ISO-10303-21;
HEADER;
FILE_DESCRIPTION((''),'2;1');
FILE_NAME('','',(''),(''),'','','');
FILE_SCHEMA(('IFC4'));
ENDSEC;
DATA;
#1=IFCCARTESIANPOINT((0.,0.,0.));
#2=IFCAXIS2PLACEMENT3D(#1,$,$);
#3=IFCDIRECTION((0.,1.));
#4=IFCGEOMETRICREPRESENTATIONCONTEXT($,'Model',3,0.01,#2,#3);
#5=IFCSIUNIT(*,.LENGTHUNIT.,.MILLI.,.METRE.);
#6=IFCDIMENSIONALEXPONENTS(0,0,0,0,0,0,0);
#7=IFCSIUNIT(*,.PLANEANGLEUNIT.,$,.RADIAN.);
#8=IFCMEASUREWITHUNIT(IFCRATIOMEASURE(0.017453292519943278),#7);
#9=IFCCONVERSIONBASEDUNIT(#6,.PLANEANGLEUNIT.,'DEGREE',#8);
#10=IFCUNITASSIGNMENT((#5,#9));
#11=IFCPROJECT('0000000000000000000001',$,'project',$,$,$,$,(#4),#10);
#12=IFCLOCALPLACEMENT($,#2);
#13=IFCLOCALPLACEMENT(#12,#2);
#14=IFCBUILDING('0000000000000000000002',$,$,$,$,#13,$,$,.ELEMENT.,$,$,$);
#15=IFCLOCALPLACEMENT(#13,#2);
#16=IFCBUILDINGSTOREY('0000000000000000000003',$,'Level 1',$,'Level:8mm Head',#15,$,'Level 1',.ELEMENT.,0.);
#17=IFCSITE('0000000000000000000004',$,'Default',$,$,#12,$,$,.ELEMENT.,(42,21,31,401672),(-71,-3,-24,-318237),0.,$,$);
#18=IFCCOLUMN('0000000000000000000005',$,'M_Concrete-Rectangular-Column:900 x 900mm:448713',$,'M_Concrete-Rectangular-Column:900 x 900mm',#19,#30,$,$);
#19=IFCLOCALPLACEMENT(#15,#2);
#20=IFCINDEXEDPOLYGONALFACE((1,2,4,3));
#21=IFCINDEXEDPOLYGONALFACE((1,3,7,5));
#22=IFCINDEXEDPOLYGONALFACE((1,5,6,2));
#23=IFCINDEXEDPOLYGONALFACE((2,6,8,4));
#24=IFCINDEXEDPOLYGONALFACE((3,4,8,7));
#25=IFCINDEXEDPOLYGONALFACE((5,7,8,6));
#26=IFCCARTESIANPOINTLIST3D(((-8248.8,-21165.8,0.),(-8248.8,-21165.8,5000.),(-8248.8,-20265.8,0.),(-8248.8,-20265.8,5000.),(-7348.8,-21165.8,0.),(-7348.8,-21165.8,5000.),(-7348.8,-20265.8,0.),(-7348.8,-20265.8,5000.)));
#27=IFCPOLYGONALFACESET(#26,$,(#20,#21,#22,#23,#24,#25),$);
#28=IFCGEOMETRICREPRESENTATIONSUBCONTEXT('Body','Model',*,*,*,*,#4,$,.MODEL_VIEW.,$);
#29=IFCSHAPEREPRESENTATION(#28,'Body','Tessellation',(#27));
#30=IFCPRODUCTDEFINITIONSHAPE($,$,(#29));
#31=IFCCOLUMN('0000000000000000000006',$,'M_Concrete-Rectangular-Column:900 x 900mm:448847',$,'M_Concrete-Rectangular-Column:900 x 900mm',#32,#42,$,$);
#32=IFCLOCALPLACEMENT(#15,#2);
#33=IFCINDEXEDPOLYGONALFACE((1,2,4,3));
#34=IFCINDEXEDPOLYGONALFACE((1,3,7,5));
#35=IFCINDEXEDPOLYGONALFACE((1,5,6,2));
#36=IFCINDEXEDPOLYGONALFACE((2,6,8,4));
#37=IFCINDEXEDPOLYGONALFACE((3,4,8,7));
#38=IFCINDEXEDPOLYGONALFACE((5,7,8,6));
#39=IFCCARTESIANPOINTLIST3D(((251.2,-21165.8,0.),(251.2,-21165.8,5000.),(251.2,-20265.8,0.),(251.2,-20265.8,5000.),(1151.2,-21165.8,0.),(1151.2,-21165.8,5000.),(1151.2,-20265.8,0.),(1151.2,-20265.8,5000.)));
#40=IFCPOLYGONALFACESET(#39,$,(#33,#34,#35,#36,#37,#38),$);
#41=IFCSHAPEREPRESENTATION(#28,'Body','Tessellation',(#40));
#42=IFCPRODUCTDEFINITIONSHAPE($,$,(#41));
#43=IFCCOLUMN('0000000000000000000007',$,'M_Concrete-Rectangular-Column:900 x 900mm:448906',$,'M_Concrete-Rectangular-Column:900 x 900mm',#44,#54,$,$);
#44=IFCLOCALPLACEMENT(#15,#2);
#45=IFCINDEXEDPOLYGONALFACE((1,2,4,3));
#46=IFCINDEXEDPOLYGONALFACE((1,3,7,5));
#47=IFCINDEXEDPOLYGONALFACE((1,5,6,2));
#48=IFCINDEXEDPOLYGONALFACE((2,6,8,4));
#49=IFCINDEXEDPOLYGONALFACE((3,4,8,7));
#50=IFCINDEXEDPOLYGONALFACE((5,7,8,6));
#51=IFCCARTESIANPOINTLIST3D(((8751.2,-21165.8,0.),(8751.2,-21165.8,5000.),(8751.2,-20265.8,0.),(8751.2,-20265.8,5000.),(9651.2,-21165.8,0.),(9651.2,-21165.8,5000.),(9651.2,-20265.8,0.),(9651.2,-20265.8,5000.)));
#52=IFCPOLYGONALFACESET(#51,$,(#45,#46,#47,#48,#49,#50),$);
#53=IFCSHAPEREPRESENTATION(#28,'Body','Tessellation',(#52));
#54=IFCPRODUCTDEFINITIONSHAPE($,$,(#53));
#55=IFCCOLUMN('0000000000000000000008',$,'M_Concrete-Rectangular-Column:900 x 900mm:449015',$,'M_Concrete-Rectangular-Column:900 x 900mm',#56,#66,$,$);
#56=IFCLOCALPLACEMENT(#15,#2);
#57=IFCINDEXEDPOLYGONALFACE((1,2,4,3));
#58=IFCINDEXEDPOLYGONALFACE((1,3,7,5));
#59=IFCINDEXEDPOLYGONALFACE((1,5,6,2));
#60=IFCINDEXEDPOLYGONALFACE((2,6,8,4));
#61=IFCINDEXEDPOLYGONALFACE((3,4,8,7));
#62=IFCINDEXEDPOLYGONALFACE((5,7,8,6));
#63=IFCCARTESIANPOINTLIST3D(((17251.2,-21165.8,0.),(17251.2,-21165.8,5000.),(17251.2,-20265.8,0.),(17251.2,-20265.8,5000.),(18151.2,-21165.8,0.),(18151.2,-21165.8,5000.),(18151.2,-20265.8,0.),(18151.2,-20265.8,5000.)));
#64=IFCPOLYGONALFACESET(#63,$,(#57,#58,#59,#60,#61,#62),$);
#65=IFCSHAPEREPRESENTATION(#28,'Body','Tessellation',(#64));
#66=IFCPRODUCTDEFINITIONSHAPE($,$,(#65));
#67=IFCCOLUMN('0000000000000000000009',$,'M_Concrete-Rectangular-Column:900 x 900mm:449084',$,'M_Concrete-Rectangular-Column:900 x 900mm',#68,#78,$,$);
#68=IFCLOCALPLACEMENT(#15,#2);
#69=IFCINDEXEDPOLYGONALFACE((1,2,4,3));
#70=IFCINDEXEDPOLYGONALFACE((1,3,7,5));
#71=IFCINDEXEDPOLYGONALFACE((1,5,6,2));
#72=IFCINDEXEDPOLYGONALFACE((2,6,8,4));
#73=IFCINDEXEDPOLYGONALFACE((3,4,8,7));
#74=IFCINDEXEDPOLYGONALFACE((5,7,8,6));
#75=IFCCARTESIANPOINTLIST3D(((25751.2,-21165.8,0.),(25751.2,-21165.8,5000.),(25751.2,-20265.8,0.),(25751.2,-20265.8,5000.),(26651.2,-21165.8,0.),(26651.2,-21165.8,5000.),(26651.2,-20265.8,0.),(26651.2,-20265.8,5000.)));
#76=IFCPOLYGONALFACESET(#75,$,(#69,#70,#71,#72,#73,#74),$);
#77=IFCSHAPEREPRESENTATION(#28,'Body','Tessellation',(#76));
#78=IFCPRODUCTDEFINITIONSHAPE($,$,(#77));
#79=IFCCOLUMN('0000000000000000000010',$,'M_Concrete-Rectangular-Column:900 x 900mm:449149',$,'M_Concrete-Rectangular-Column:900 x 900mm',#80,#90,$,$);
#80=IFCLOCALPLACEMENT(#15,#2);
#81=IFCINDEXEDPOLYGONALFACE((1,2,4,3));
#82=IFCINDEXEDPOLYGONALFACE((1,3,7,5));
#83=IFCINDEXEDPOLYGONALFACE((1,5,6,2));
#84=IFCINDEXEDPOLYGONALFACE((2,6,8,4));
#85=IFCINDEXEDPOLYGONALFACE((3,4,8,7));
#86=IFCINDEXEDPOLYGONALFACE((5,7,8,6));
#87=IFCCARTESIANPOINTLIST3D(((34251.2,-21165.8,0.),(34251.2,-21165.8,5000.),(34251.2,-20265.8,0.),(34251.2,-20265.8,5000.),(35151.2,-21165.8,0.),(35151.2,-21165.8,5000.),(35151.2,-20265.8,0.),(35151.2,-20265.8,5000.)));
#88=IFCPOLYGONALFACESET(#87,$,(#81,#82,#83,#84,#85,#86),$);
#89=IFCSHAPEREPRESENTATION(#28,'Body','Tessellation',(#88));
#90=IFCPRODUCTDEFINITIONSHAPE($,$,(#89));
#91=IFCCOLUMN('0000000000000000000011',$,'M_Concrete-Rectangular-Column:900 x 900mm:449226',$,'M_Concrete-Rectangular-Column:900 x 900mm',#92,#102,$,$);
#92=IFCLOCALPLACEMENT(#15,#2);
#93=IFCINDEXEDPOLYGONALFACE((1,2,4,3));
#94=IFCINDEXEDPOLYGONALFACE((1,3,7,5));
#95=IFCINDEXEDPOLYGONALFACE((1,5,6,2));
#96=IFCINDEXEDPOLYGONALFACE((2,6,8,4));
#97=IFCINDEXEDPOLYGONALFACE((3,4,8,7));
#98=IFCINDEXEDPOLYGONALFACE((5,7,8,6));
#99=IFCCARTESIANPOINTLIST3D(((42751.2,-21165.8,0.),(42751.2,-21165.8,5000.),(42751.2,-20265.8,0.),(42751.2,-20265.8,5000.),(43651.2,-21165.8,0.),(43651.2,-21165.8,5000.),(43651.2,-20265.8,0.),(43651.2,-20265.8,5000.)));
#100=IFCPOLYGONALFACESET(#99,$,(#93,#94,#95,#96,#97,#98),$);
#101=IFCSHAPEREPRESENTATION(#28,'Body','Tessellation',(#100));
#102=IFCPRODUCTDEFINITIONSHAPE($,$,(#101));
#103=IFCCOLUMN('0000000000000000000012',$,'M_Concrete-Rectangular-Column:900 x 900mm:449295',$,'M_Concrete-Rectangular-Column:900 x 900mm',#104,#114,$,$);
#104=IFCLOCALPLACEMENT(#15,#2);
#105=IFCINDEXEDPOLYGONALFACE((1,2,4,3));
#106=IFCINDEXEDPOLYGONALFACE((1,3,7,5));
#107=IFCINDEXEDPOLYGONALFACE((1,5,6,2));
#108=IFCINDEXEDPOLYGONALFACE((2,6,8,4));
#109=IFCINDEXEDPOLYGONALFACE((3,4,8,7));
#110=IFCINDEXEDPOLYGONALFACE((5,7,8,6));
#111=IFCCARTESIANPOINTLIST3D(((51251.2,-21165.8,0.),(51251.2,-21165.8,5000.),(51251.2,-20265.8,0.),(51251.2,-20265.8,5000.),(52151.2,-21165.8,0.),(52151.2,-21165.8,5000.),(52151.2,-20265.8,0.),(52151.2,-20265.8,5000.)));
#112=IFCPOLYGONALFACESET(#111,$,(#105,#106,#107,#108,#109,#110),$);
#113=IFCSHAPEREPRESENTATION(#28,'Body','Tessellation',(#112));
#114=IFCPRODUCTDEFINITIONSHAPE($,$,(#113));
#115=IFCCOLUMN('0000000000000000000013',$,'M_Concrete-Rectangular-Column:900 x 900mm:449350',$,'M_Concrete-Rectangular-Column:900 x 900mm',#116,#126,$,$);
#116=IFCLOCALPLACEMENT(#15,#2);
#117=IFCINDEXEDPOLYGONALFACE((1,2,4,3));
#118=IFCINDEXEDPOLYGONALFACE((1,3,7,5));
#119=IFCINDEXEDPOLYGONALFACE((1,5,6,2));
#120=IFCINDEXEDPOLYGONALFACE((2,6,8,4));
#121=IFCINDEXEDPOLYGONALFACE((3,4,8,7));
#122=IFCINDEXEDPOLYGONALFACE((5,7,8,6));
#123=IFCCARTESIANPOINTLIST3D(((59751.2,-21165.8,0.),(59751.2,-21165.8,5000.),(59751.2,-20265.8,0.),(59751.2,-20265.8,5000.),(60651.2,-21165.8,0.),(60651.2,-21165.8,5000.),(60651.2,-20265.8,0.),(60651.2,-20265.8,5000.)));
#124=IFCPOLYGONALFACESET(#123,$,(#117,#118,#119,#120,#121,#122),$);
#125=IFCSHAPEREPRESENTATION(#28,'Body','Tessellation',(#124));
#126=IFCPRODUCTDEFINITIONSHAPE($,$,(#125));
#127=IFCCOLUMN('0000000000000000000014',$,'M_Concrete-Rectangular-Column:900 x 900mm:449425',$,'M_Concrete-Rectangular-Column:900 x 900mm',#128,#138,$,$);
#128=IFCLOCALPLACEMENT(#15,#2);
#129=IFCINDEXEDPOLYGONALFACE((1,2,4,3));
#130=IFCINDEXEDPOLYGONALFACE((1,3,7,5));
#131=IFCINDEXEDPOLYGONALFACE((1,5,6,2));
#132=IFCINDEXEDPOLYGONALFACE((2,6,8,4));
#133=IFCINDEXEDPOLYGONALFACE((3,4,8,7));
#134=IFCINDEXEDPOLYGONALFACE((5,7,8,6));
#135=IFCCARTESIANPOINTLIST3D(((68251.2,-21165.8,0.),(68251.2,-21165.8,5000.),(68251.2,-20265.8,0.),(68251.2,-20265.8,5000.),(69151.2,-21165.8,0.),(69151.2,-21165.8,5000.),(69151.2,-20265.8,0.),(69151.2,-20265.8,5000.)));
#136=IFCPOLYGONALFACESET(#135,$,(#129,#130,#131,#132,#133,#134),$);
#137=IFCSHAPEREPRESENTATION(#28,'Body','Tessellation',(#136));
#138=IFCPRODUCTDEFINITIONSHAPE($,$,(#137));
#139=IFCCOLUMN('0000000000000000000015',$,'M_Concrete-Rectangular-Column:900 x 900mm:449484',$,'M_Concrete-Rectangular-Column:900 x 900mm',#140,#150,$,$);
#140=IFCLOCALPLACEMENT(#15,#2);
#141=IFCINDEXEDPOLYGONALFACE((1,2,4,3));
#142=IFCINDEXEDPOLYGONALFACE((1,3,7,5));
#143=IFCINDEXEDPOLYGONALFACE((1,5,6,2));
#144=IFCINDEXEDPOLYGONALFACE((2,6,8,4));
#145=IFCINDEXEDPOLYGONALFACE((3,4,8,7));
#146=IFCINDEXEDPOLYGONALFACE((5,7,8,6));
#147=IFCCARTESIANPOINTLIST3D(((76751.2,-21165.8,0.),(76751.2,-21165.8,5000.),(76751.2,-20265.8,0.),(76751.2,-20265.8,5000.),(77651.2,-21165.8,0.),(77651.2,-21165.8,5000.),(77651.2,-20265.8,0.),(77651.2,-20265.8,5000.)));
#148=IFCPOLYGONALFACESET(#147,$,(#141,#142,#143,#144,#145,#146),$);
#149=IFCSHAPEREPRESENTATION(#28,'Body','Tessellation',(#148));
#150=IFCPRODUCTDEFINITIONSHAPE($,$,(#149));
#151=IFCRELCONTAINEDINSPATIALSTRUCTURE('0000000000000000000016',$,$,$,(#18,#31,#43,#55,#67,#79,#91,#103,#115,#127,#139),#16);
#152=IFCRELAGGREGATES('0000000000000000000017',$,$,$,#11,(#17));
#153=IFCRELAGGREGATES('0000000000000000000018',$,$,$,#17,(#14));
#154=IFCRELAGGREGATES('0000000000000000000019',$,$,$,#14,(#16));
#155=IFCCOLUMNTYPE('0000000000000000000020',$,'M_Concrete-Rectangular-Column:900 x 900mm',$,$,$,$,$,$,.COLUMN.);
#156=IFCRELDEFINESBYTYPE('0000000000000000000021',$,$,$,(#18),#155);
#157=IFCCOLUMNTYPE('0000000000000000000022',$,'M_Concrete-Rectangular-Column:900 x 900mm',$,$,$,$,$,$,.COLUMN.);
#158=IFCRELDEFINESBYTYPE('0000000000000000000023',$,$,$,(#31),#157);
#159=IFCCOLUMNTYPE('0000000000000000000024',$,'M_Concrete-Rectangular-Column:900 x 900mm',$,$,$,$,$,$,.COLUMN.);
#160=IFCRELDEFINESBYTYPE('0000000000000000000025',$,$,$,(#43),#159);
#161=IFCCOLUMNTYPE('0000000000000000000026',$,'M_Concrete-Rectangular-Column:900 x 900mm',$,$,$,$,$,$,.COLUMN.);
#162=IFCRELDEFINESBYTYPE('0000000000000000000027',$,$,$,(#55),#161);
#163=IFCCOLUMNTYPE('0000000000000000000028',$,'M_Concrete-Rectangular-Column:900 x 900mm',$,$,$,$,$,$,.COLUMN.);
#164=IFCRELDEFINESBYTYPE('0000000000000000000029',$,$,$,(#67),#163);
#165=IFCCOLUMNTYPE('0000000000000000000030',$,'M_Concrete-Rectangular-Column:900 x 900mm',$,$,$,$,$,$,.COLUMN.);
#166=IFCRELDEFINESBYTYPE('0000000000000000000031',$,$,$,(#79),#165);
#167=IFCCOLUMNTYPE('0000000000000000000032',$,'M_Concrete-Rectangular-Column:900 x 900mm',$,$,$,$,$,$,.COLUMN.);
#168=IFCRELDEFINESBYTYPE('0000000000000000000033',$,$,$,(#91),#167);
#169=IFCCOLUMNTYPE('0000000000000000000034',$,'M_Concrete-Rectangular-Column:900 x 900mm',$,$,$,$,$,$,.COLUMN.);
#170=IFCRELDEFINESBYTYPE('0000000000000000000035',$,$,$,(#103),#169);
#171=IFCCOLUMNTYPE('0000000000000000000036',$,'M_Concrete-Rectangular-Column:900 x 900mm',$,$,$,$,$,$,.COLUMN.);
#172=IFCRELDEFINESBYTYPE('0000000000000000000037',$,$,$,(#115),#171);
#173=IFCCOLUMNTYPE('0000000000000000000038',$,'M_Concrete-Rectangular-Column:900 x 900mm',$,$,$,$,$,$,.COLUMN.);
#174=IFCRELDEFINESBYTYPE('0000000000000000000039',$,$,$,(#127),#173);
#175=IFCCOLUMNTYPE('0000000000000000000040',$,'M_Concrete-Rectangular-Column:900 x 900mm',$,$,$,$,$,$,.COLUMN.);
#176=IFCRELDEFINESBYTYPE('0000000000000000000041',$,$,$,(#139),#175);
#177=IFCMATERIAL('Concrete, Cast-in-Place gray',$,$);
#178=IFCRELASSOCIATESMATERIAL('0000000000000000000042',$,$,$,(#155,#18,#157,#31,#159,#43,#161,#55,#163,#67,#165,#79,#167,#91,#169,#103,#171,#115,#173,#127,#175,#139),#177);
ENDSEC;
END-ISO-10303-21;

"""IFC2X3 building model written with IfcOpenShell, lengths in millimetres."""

from ifc_helpers import new_model, entity, si_unit, converted_unit, direction, frame, frame_2d, origin, origin_2d_with_axis, place, context, subcontext, project, spatial, rectangle, extrude, source, transform, mapped, material, type_object, type_shapes, element, save


model = new_model("IFC2X3")

# Units and contexts
model_context = context("Model", 3, precision=0.01, world=origin(), true_north=direction((0.0, 1.0)))
body_context = subcontext(model_context, "Body", "Model", "MODEL_VIEW")
ifc_project = project(units=[si_unit("LENGTHUNIT", "METRE", prefix="MILLI"), converted_unit("PLANEANGLEUNIT", "DEGREE", entity("IfcRatioMeasure", 0.017453292519943278), si_unit("PLANEANGLEUNIT", "RADIAN"), dimensions=[0, 0, 0, 0, 0, 0, 0])], contexts=[model_context])

# Site, building, storey
site_placement = place(None, origin())
site = spatial("IfcSite", under=ifc_project, at=site_placement, Name="Default", CompositionType="ELEMENT", RefLatitude=(42, 21, 31, 401672), RefLongitude=(-71, -3, -24, -318237), RefElevation=0.0)
building_placement = place(site_placement, origin())
building = spatial("IfcBuilding", under=site, at=building_placement, CompositionType="ELEMENT")
storey_placement = place(building_placement, origin())
storey = spatial("IfcBuildingStorey", under=building, at=storey_placement, Name="Level 1", ObjectType="Level:8mm Head", LongName="Level 1", CompositionType="ELEMENT", Elevation=0.0)

# Columns
ifc_material_1 = material(Name="Concrete, Cast-in-Place gray")
column_type_1 = type_object("IfcColumnType", Name="M_Concrete-Rectangular-Column:900 x 900mm", PredefinedType="COLUMN", material=ifc_material_1)
shared_shape_1 = source(origin(), body_context, "Body", "SweptSolid", [
    extrude(rectangle(XDim=900.0, YDim=900.0, at=frame_2d((0.0, 0.0), x_axis=(1.0, 0.0))), frame((-7798.8, -20715.8, 0.0), z_axis=(0.0, 0.0, 1.0), x_axis=(0.0, -1.0, 0.0)), (0.0, 0.0, 1.0), 5000.0),
])
type_shapes(column_type_1, [shared_shape_1])
column_1_placement = place(storey_placement, origin())
element("IfcColumn", 1, at=column_1_placement, inside=storey, type_object=column_type_1, material=ifc_material_1, Name="M_Concrete-Rectangular-Column:900 x 900mm:448713", ObjectType="M_Concrete-Rectangular-Column:900 x 900mm", context=body_context, shape_type="MappedRepresentation", body=[
    mapped(shared_shape_1, transform((0.0, 0.0, 0.0), scale=1.0)),
])
column_type_2 = type_object("IfcColumnType", Name="M_Concrete-Rectangular-Column:900 x 900mm", PredefinedType="COLUMN", material=ifc_material_1)
shared_shape_2 = source(origin(), body_context, "Body", "SweptSolid", [
    extrude(rectangle(XDim=900.0, YDim=900.0, at=frame_2d((0.0, 0.0), x_axis=(1.0, 0.0))), frame((701.2, -20715.8, 0.0), z_axis=(0.0, 0.0, 1.0), x_axis=(0.0, -1.0, 0.0)), (0.0, 0.0, 1.0), 5000.0),
])
type_shapes(column_type_2, [shared_shape_2])
column_2_placement = place(storey_placement, origin())
element("IfcColumn", 2, at=column_2_placement, inside=storey, type_object=column_type_2, material=ifc_material_1, Name="M_Concrete-Rectangular-Column:900 x 900mm:448847", ObjectType="M_Concrete-Rectangular-Column:900 x 900mm", context=body_context, shape_type="MappedRepresentation", body=[
    mapped(shared_shape_2, transform((0.0, 0.0, 0.0), scale=1.0)),
])
column_type_3 = type_object("IfcColumnType", Name="M_Concrete-Rectangular-Column:900 x 900mm", PredefinedType="COLUMN", material=ifc_material_1)
shared_shape_3 = source(origin(), body_context, "Body", "SweptSolid", [
    extrude(rectangle(XDim=900.0, YDim=900.0, at=frame_2d((0.0, 0.0), x_axis=(1.0, 0.0))), frame((9201.2, -20715.8, 0.0), z_axis=(0.0, 0.0, 1.0), x_axis=(0.0, -1.0, 0.0)), (0.0, 0.0, 1.0), 5000.0),
])
type_shapes(column_type_3, [shared_shape_3])
column_3_placement = place(storey_placement, origin())
element("IfcColumn", 3, at=column_3_placement, inside=storey, type_object=column_type_3, material=ifc_material_1, Name="M_Concrete-Rectangular-Column:900 x 900mm:448906", ObjectType="M_Concrete-Rectangular-Column:900 x 900mm", context=body_context, shape_type="MappedRepresentation", body=[
    mapped(shared_shape_3, transform((0.0, 0.0, 0.0), scale=1.0)),
])
column_type_4 = type_object("IfcColumnType", Name="M_Concrete-Rectangular-Column:900 x 900mm", PredefinedType="COLUMN", material=ifc_material_1)
shared_shape_4 = source(origin(), body_context, "Body", "SweptSolid", [
    extrude(rectangle(XDim=900.0, YDim=900.0, at=frame_2d((0.0, 0.0), x_axis=(1.0, 0.0))), frame((17701.2, -20715.8, 0.0), z_axis=(0.0, 0.0, 1.0), x_axis=(0.0, -1.0, 0.0)), (0.0, 0.0, 1.0), 5000.0),
])
type_shapes(column_type_4, [shared_shape_4])
column_4_placement = place(storey_placement, origin())
element("IfcColumn", 4, at=column_4_placement, inside=storey, type_object=column_type_4, material=ifc_material_1, Name="M_Concrete-Rectangular-Column:900 x 900mm:449015", ObjectType="M_Concrete-Rectangular-Column:900 x 900mm", context=body_context, shape_type="MappedRepresentation", body=[
    mapped(shared_shape_4, transform((0.0, 0.0, 0.0), scale=1.0)),
])
column_type_5 = type_object("IfcColumnType", Name="M_Concrete-Rectangular-Column:900 x 900mm", PredefinedType="COLUMN", material=ifc_material_1)
shared_shape_5 = source(origin(), body_context, "Body", "SweptSolid", [
    extrude(rectangle(XDim=900.0, YDim=900.0, at=origin_2d_with_axis()), frame((26201.2, -20715.8, 0.0), z_axis=(0.0, 0.0, 1.0), x_axis=(0.0, -1.0, 0.0)), (0.0, 0.0, 1.0), 5000.0),
])
type_shapes(column_type_5, [shared_shape_5])
column_5_placement = place(storey_placement, origin())
element("IfcColumn", 5, at=column_5_placement, inside=storey, type_object=column_type_5, material=ifc_material_1, Name="M_Concrete-Rectangular-Column:900 x 900mm:449084", ObjectType="M_Concrete-Rectangular-Column:900 x 900mm", context=body_context, shape_type="MappedRepresentation", body=[
    mapped(shared_shape_5, transform((0.0, 0.0, 0.0), scale=1.0)),
])
column_type_6 = type_object("IfcColumnType", Name="M_Concrete-Rectangular-Column:900 x 900mm", PredefinedType="COLUMN", material=ifc_material_1)
shared_shape_6 = source(origin(), body_context, "Body", "SweptSolid", [
    extrude(rectangle(XDim=900.0, YDim=900.0, at=origin_2d_with_axis()), frame((34701.2, -20715.8, 0.0), z_axis=(0.0, 0.0, 1.0), x_axis=(0.0, -1.0, 0.0)), (0.0, 0.0, 1.0), 5000.0),
])
type_shapes(column_type_6, [shared_shape_6])
column_6_placement = place(storey_placement, origin())
element("IfcColumn", 6, at=column_6_placement, inside=storey, type_object=column_type_6, material=ifc_material_1, Name="M_Concrete-Rectangular-Column:900 x 900mm:449149", ObjectType="M_Concrete-Rectangular-Column:900 x 900mm", context=body_context, shape_type="MappedRepresentation", body=[
    mapped(shared_shape_6, transform((0.0, 0.0, 0.0), scale=1.0)),
])
column_type_7 = type_object("IfcColumnType", Name="M_Concrete-Rectangular-Column:900 x 900mm", PredefinedType="COLUMN", material=ifc_material_1)
shared_shape_7 = source(origin(), body_context, "Body", "SweptSolid", [
    extrude(rectangle(XDim=900.0, YDim=900.0, at=origin_2d_with_axis()), frame((43201.2, -20715.8, 0.0), z_axis=(0.0, 0.0, 1.0), x_axis=(0.0, -1.0, 0.0)), (0.0, 0.0, 1.0), 5000.0),
])
type_shapes(column_type_7, [shared_shape_7])
column_7_placement = place(storey_placement, origin())
element("IfcColumn", 7, at=column_7_placement, inside=storey, type_object=column_type_7, material=ifc_material_1, Name="M_Concrete-Rectangular-Column:900 x 900mm:449226", ObjectType="M_Concrete-Rectangular-Column:900 x 900mm", context=body_context, shape_type="MappedRepresentation", body=[
    mapped(shared_shape_7, transform((0.0, 0.0, 0.0), scale=1.0)),
])
column_type_8 = type_object("IfcColumnType", Name="M_Concrete-Rectangular-Column:900 x 900mm", PredefinedType="COLUMN", material=ifc_material_1)
shared_shape_8 = source(origin(), body_context, "Body", "SweptSolid", [
    extrude(rectangle(XDim=900.0, YDim=900.0, at=origin_2d_with_axis()), frame((51701.2, -20715.8, 0.0), z_axis=(0.0, 0.0, 1.0), x_axis=(0.0, -1.0, 0.0)), (0.0, 0.0, 1.0), 5000.0),
])
type_shapes(column_type_8, [shared_shape_8])
column_8_placement = place(storey_placement, origin())
element("IfcColumn", 8, at=column_8_placement, inside=storey, type_object=column_type_8, material=ifc_material_1, Name="M_Concrete-Rectangular-Column:900 x 900mm:449295", ObjectType="M_Concrete-Rectangular-Column:900 x 900mm", context=body_context, shape_type="MappedRepresentation", body=[
    mapped(shared_shape_8, transform((0.0, 0.0, 0.0), scale=1.0)),
])
column_type_9 = type_object("IfcColumnType", Name="M_Concrete-Rectangular-Column:900 x 900mm", PredefinedType="COLUMN", material=ifc_material_1)
shared_shape_9 = source(origin(), body_context, "Body", "SweptSolid", [
    extrude(rectangle(XDim=900.0, YDim=900.0, at=origin_2d_with_axis()), frame((60201.2, -20715.8, 0.0), z_axis=(0.0, 0.0, 1.0), x_axis=(0.0, -1.0, 0.0)), (0.0, 0.0, 1.0), 5000.0),
])
type_shapes(column_type_9, [shared_shape_9])
column_9_placement = place(storey_placement, origin())
element("IfcColumn", 9, at=column_9_placement, inside=storey, type_object=column_type_9, material=ifc_material_1, Name="M_Concrete-Rectangular-Column:900 x 900mm:449350", ObjectType="M_Concrete-Rectangular-Column:900 x 900mm", context=body_context, shape_type="MappedRepresentation", body=[
    mapped(shared_shape_9, transform((0.0, 0.0, 0.0), scale=1.0)),
])
column_type_10 = type_object("IfcColumnType", Name="M_Concrete-Rectangular-Column:900 x 900mm", PredefinedType="COLUMN", material=ifc_material_1)
shared_shape_10 = source(origin(), body_context, "Body", "SweptSolid", [
    extrude(rectangle(XDim=900.0, YDim=900.0, at=origin_2d_with_axis()), frame((68701.2, -20715.8, 0.0), z_axis=(0.0, 0.0, 1.0), x_axis=(0.0, -1.0, 0.0)), (0.0, 0.0, 1.0), 5000.0),
])
type_shapes(column_type_10, [shared_shape_10])
column_10_placement = place(storey_placement, origin())
element("IfcColumn", 10, at=column_10_placement, inside=storey, type_object=column_type_10, material=ifc_material_1, Name="M_Concrete-Rectangular-Column:900 x 900mm:449425", ObjectType="M_Concrete-Rectangular-Column:900 x 900mm", context=body_context, shape_type="MappedRepresentation", body=[
    mapped(shared_shape_10, transform((0.0, 0.0, 0.0), scale=1.0)),
])
column_type_11 = type_object("IfcColumnType", Name="M_Concrete-Rectangular-Column:900 x 900mm", PredefinedType="COLUMN", material=ifc_material_1)
shared_shape_11 = source(origin(), body_context, "Body", "SweptSolid", [
    extrude(rectangle(XDim=900.0, YDim=900.0, at=origin_2d_with_axis()), frame((77201.2, -20715.8, 0.0), z_axis=(0.0, 0.0, 1.0), x_axis=(0.0, -1.0, 0.0)), (0.0, 0.0, 1.0), 5000.0),
])
type_shapes(column_type_11, [shared_shape_11])
column_11_placement = place(storey_placement, origin())
element("IfcColumn", 11, at=column_11_placement, inside=storey, type_object=column_type_11, material=ifc_material_1, Name="M_Concrete-Rectangular-Column:900 x 900mm:449484", ObjectType="M_Concrete-Rectangular-Column:900 x 900mm", context=body_context, shape_type="MappedRepresentation", body=[
    mapped(shared_shape_11, transform((0.0, 0.0, 0.0), scale=1.0)),
])

save(model, "model.ifc")
